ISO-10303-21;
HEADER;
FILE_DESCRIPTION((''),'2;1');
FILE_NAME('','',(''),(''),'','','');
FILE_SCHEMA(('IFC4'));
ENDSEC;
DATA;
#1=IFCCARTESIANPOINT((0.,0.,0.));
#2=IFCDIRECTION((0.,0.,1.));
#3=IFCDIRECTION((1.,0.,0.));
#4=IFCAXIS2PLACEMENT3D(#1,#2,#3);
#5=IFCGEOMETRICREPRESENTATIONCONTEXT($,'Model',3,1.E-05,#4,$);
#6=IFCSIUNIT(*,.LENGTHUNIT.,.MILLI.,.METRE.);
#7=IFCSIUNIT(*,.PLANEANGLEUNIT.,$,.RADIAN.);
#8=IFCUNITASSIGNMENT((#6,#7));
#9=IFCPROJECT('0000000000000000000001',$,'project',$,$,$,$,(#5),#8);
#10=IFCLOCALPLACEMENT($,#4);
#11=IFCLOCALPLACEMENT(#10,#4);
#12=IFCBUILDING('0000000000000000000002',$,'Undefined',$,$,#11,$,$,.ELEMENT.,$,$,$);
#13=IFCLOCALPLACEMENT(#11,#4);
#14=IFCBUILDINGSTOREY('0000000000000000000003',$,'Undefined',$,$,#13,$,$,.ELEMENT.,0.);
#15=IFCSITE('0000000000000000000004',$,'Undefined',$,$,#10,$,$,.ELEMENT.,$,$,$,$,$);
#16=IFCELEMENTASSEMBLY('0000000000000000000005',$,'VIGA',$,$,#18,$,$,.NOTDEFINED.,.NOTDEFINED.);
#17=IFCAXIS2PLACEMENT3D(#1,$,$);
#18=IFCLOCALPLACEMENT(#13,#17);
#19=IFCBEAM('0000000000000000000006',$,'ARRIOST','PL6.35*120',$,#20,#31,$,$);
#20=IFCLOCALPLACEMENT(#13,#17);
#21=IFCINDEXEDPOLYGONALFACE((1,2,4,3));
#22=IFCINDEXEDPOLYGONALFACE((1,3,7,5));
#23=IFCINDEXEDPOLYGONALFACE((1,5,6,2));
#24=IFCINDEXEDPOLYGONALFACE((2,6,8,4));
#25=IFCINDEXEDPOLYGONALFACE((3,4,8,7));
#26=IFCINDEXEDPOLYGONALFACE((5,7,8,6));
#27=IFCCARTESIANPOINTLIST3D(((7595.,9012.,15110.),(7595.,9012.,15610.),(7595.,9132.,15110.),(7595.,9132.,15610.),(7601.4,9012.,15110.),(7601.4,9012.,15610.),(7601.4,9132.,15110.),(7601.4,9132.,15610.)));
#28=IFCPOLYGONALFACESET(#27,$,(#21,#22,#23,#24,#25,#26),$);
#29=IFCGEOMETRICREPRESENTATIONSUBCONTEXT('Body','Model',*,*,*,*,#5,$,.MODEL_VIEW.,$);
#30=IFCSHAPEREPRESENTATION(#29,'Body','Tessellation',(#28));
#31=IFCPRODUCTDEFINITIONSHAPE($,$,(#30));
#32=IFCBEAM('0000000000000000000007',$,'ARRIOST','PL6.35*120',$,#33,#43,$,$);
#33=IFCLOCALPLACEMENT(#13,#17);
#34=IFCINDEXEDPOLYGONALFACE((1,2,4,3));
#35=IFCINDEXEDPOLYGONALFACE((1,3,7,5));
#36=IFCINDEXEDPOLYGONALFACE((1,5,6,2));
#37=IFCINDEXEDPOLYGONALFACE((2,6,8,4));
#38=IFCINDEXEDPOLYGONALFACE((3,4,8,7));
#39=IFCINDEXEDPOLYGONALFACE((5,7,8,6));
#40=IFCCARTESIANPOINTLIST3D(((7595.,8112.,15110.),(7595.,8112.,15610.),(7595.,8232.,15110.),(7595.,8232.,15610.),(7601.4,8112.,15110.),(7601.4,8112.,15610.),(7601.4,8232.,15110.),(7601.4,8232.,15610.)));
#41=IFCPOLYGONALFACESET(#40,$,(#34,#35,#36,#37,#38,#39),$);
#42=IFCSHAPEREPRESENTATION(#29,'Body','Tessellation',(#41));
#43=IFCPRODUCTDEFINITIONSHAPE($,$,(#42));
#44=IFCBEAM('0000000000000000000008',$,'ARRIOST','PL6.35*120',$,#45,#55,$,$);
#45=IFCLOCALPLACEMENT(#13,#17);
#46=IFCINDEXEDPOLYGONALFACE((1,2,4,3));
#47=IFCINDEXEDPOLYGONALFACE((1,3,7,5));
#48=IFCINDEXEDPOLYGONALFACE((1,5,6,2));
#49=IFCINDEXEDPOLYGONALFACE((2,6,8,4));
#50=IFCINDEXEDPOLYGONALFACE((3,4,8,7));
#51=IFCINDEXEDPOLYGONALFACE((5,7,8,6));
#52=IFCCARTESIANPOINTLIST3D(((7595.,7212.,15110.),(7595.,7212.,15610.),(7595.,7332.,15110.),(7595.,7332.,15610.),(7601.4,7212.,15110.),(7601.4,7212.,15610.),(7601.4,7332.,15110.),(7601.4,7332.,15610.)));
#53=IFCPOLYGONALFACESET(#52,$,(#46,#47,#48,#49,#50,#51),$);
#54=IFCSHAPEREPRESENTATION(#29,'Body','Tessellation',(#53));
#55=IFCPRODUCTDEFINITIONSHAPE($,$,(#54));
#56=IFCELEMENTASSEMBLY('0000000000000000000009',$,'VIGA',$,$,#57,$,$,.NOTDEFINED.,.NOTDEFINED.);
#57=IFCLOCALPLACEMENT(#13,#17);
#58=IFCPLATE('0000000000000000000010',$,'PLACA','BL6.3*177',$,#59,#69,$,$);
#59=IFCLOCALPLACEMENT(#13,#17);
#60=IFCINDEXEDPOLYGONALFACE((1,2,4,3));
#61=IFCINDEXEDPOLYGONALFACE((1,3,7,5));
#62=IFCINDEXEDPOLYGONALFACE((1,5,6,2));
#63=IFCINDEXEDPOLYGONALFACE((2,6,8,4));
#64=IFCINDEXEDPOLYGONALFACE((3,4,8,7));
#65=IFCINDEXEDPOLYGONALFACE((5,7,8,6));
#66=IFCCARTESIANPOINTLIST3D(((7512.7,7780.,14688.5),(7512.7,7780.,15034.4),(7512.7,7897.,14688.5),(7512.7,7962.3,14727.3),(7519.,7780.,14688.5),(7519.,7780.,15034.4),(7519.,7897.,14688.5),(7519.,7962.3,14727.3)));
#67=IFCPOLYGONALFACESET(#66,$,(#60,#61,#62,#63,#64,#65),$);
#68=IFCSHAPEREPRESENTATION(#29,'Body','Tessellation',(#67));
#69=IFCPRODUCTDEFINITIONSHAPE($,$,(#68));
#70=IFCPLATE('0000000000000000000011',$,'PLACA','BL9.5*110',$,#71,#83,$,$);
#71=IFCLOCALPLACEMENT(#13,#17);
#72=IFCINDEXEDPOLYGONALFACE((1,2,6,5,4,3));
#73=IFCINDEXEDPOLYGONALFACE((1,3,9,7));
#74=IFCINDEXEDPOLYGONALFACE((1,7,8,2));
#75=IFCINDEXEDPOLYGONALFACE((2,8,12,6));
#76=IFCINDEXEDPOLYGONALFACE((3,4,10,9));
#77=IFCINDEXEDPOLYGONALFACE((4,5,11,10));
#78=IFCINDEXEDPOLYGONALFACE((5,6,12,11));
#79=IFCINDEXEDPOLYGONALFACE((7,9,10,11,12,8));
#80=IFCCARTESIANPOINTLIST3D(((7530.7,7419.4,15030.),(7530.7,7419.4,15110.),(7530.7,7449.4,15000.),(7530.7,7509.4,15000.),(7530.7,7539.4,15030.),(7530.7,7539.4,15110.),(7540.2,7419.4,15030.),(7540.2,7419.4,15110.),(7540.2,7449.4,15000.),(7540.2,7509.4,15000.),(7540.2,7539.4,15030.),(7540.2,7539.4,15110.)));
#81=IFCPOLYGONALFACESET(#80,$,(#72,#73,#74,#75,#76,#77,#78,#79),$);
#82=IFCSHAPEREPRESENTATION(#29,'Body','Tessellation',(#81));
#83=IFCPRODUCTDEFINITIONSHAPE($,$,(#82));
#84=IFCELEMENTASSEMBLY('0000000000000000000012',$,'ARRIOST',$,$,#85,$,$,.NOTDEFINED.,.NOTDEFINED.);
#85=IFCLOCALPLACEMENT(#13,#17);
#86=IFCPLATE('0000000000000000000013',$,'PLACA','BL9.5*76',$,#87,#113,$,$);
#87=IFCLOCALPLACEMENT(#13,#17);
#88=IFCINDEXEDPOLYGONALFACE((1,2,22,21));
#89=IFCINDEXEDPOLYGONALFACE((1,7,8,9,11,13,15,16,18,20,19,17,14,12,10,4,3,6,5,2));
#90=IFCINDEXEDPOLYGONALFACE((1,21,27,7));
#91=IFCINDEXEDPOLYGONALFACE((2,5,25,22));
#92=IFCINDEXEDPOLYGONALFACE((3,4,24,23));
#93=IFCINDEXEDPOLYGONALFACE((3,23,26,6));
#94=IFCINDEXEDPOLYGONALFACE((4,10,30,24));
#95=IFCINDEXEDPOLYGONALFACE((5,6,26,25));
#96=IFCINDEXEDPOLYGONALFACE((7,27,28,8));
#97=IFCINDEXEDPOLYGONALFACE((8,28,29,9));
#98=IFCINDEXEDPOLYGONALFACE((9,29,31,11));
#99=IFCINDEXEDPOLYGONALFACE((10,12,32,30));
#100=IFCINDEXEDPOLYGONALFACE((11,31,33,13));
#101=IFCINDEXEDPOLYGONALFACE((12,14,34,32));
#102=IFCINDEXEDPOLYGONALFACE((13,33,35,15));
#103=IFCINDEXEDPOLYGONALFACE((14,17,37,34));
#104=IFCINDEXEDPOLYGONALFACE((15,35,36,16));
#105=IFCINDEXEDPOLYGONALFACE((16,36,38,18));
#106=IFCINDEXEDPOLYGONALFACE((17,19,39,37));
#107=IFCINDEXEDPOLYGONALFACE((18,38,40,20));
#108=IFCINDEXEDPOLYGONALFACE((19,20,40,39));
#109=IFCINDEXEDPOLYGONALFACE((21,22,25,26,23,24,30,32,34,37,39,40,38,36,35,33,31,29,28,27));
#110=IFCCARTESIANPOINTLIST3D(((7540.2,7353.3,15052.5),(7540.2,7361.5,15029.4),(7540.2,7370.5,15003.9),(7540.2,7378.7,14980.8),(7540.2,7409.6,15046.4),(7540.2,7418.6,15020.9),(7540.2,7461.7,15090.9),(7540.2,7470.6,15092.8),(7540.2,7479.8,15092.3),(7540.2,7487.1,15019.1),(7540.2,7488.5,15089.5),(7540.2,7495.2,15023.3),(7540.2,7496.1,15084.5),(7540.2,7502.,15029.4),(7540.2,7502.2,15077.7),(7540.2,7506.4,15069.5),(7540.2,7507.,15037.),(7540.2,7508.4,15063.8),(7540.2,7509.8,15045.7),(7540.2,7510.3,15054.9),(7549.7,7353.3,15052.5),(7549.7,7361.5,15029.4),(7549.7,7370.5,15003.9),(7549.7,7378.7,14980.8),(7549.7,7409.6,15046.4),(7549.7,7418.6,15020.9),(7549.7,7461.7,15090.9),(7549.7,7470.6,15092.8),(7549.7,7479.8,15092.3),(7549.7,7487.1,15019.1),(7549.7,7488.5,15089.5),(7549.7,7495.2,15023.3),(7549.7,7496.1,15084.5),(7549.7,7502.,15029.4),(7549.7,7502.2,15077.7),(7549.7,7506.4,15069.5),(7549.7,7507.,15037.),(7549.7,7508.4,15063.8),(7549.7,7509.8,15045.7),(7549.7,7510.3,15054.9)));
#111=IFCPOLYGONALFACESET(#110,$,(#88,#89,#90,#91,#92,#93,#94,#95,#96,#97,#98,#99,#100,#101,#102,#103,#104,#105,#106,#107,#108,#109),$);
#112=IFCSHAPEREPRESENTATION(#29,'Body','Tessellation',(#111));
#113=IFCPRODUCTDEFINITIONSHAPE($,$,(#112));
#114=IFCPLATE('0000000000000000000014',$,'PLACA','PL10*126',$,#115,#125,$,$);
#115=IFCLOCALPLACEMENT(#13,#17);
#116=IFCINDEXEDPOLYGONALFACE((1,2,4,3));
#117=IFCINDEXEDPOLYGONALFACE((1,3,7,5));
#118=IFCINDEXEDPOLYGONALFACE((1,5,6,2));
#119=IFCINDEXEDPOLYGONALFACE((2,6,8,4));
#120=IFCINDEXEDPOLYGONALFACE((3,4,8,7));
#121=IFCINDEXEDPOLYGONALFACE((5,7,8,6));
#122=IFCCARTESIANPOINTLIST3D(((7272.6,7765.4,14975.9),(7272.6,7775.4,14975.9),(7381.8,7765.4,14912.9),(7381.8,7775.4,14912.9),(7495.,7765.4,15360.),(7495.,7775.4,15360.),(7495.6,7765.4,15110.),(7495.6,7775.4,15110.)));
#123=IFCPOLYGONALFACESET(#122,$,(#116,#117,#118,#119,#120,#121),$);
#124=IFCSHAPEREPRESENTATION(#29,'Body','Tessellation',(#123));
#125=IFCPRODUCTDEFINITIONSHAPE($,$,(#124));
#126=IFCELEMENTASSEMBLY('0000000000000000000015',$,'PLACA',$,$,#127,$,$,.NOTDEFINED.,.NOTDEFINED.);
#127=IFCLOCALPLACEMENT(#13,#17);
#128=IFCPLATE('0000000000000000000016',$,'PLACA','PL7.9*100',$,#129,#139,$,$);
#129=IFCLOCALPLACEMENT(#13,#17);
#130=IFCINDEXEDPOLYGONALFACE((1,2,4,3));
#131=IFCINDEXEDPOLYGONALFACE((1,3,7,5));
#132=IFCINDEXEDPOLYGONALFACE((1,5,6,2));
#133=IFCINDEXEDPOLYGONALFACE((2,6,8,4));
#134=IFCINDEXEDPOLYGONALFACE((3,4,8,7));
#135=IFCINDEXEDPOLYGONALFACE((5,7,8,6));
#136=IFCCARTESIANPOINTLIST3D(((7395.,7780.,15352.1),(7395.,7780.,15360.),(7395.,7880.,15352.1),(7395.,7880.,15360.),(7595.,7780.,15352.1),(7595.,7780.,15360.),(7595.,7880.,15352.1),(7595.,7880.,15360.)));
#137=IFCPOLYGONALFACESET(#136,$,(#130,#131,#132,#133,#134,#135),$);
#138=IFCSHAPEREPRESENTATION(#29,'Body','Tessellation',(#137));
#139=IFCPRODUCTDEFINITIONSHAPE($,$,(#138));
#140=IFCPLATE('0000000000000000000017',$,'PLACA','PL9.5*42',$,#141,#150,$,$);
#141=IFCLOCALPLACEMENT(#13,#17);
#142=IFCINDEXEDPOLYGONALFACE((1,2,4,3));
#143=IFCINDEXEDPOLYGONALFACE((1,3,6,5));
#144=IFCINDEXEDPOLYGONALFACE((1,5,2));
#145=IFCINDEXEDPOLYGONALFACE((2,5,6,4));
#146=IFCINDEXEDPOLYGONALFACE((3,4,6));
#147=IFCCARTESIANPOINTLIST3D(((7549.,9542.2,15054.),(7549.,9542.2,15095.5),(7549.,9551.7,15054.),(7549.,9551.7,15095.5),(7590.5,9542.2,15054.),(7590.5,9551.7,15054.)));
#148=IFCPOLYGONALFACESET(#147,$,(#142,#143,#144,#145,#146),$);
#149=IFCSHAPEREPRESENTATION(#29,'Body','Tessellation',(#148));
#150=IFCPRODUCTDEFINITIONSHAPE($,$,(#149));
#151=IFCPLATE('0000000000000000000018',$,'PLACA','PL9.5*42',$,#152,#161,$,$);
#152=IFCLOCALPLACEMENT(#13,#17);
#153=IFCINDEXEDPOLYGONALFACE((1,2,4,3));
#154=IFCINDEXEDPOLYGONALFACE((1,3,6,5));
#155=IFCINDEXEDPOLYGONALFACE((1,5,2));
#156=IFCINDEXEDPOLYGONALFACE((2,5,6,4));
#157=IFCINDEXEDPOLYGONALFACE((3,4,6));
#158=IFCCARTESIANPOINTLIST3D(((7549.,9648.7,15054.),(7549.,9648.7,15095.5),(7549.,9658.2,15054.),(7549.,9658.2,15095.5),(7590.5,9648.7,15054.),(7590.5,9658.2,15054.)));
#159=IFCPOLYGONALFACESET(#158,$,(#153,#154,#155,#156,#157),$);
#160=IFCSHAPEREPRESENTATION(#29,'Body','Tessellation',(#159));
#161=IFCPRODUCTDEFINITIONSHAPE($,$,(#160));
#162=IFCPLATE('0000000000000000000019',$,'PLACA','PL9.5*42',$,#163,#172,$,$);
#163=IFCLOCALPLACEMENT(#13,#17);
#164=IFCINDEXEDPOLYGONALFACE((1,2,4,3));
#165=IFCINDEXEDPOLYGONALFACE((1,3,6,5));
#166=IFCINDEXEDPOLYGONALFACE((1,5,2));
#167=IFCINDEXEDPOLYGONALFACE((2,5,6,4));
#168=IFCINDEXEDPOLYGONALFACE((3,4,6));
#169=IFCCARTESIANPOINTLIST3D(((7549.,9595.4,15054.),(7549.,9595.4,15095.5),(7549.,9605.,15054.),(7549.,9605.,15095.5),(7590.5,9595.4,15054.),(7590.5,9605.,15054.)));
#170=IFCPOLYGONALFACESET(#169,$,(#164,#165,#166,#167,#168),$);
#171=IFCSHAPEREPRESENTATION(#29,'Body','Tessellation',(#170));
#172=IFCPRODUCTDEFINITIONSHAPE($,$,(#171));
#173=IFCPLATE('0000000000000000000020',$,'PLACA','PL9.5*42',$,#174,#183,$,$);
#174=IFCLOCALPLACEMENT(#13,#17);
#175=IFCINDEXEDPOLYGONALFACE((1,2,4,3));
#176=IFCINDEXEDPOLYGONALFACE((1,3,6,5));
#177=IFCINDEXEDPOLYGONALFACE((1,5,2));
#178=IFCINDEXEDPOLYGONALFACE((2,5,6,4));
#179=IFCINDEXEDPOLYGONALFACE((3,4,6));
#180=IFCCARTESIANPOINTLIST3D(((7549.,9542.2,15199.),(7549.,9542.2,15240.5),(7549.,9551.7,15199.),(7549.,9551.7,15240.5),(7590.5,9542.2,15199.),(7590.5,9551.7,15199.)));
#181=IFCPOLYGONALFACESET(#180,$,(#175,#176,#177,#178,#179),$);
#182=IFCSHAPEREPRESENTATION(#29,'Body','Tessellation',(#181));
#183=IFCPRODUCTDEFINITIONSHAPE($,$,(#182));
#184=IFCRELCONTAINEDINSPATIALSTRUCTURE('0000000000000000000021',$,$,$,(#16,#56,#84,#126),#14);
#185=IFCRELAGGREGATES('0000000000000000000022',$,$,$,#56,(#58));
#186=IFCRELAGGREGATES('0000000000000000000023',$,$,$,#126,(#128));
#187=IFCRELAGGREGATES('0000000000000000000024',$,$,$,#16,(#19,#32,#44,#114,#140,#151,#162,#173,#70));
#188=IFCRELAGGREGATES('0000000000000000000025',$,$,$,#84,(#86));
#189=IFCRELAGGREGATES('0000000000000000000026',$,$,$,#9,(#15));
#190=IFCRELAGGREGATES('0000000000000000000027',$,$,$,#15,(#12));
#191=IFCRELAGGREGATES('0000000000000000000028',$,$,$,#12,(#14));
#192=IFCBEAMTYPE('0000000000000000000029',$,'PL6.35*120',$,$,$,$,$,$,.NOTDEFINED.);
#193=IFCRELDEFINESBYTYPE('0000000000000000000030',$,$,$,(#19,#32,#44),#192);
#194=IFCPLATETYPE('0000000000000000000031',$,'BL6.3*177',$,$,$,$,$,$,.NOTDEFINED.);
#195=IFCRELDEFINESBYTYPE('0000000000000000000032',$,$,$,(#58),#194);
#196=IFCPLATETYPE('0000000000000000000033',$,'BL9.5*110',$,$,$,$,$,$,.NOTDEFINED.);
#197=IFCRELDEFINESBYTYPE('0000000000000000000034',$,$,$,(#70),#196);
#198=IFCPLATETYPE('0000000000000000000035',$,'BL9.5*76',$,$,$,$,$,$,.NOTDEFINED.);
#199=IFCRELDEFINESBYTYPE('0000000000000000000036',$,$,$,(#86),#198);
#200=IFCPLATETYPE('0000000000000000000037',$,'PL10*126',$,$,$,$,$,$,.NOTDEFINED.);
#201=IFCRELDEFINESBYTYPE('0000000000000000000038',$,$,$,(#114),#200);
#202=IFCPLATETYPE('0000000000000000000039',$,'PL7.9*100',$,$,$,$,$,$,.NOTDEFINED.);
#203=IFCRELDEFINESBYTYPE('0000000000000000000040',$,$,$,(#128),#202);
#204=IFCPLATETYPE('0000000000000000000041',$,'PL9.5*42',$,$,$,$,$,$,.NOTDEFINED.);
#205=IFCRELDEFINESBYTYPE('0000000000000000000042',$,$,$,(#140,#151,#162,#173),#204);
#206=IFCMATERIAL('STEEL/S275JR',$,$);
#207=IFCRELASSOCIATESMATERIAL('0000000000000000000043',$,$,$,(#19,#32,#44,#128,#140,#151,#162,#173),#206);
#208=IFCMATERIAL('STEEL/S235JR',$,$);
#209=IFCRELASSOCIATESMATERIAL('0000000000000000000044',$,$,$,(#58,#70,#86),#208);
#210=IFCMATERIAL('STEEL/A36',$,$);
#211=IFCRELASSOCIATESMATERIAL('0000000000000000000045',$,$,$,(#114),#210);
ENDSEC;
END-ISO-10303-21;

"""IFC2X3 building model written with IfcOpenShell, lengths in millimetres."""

from ifc_helpers import new_model, si_unit, frame, frame_2d, origin_with_axes, origin_2d_with_axis, place, context, subcontext, project, spatial, polyline, circle_curve, parameter, trimmed, segment, composite_curve, rectangle, outline, extrude, boolean, material, type_object, element, aggregate, save


model = new_model("IFC2X3")

# Units and contexts
model_context = context("Model", 3, precision=1e-05, world=origin_with_axes())
body_context = subcontext(model_context, "Body", "Model", "MODEL_VIEW")
ifc_project = project(units=[si_unit("LENGTHUNIT", "METRE", prefix="MILLI"), si_unit("PLANEANGLEUNIT", "RADIAN")], contexts=[model_context])

# Site, building, storey
site_placement = place(None, origin_with_axes())
site = spatial("IfcSite", under=ifc_project, at=site_placement, Name="Undefined", CompositionType="ELEMENT")
building_placement = place(site_placement, origin_with_axes())
building = spatial("IfcBuilding", under=site, at=building_placement, Name="Undefined", CompositionType="ELEMENT")
storey_placement = place(building_placement, origin_with_axes())
storey = spatial("IfcBuildingStorey", under=building, at=storey_placement, Name="Undefined", CompositionType="ELEMENT", Elevation=0.0)

# Element assembly, beams
assembly_1_placement = place(storey_placement, origin_with_axes())
assembly_1 = element("IfcElementAssembly", 1, at=assembly_1_placement, inside=storey, Name="VIGA", AssemblyPlace="NOTDEFINED", PredefinedType="NOTDEFINED")
ifc_material_1 = material(Name="STEEL/S275JR")
beam_type_1 = type_object("IfcBeamType", Name="PL6.35*120", PredefinedType="NOTDEFINED")
beam_1_placement = place(assembly_1_placement, frame((7598.2, 9072.0, 15110.0), z_axis=(0.0, 1.0, 0.0), x_axis=(0.0, 0.0, 1.0)))
beam_1 = element("IfcBeam", 2, at=beam_1_placement, type_object=beam_type_1, material=ifc_material_1, Name="ARRIOST", Description="PL6.35*120", context=body_context, shape_type="SweptSolid", body=[
    extrude(rectangle(XDim=6.3, YDim=120.0, at=origin_2d_with_axis()), frame((500.0, 0.0, 0.0), z_axis=(-1.0, 0.0, 0.0), x_axis=(0.0, -1.0, 0.0)), (0.0, 0.0, 1.0), 500.0),
])
beam_2_placement = place(assembly_1_placement, frame((7598.2, 8172.0, 15110.0), z_axis=(0.0, 1.0, 0.0), x_axis=(0.0, 0.0, 1.0)))
beam_2 = element("IfcBeam", 3, at=beam_2_placement, type_object=beam_type_1, material=ifc_material_1, Name="ARRIOST", Description="PL6.35*120", context=body_context, shape_type="SweptSolid", body=[
    extrude(rectangle(XDim=6.3, YDim=120.0, at=origin_2d_with_axis()), frame((500.0, 0.0, 0.0), z_axis=(-1.0, 0.0, 0.0), x_axis=(0.0, -1.0, 0.0)), (0.0, 0.0, 1.0), 500.0),
])
beam_3_placement = place(assembly_1_placement, frame((7598.2, 7272.0, 15110.0), z_axis=(0.0, 1.0, 0.0), x_axis=(0.0, 0.0, 1.0)))
beam_3 = element("IfcBeam", 4, at=beam_3_placement, type_object=beam_type_1, material=ifc_material_1, Name="ARRIOST", Description="PL6.35*120", context=body_context, shape_type="SweptSolid", body=[
    extrude(rectangle(XDim=6.3, YDim=120.0, at=origin_2d_with_axis()), frame((500.0, 0.0, 0.0), z_axis=(-1.0, 0.0, 0.0), x_axis=(0.0, -1.0, 0.0)), (0.0, 0.0, 1.0), 500.0),
])

# Element assembly, plate
assembly_2_placement = place(storey_placement, origin_with_axes())
assembly_2 = element("IfcElementAssembly", 5, at=assembly_2_placement, inside=storey, Name="VIGA", AssemblyPlace="NOTDEFINED", PredefinedType="NOTDEFINED")
ifc_material_2 = material(Name="STEEL/S235JR")
plate_type_1 = type_object("IfcPlateType", Name="BL6.3*177", PredefinedType="NOTDEFINED")
plate_1_placement = place(assembly_2_placement, frame((7515.9, 7780.0, 15034.4), z_axis=(1.0, 0.0, 0.0), x_axis=(0.0, 0.0, -1.0)))
plate_1 = element("IfcPlate", 6, at=plate_1_placement, type_object=plate_type_1, material=ifc_material_2, Name="PLACA", Description="BL6.3*177", context=body_context, shape_type="SweptSolid", body=[
    extrude(outline(polyline([(0.0, 0.0), (346.0, 0.0), (346.0, 117.0), (307.2, 182.3), (0.0, 0.0)])), frame((0.0, 0.0, -3.1), z_axis=(0.0, 0.0, 1.0), x_axis=(1.0, 0.0, 0.0)), (0.0, 0.0, 1.0), 6.3),
])
aggregate(assembly_2, [plate_1])

# Plate
plate_type_2 = type_object("IfcPlateType", Name="BL9.5*110", PredefinedType="NOTDEFINED")
plate_2_placement = place(assembly_1_placement, frame((7535.5, 7419.4, 15110.0), z_axis=(1.0, 0.0, 0.0), x_axis=(0.0, 0.0, -1.0)))
plate_2 = element("IfcPlate", 7, at=plate_2_placement, type_object=plate_type_2, material=ifc_material_2, Name="PLACA", Description="BL9.5*110", context=body_context, shape_type="SweptSolid", body=[
    extrude(outline(polyline([(0.0, 0.0), (80.0, 0.0), (110.0, 30.0), (110.0, 90.0), (80.0, 120.0), (0.0, 120.0), (0.0, 0.0)])), frame((0.0, 0.0, -4.7), z_axis=(0.0, 0.0, 1.0), x_axis=(1.0, 0.0, 0.0)), (0.0, 0.0, 1.0), 9.5),
])

# Element assembly, plate
assembly_3_placement = place(storey_placement, origin_with_axes())
assembly_3 = element("IfcElementAssembly", 8, at=assembly_3_placement, inside=storey, Name="ARRIOST", AssemblyPlace="NOTDEFINED", PredefinedType="NOTDEFINED")
plate_type_3 = type_object("IfcPlateType", Name="BL9.5*76", PredefinedType="NOTDEFINED")
plate_3_placement = place(assembly_3_placement, frame((7545.0, 7520.1, 15030.8), z_axis=(1.0, 0.0, 0.0), x_axis=(0.0, -0.333429, 0.942775)))
plate_3 = element("IfcPlate", 9, at=plate_3_placement, type_object=plate_type_3, material=ifc_material_2, Name="PLACA", Description="BL9.5*76", context=body_context, shape_type="CSG", body=[
    boolean("DIFFERENCE", extrude(outline(composite_curve([segment(trimmed(circle_curve(frame_2d((35.0, 35.0), x_axis=(-1.0, 0.0)), 35.0), [parameter(0.0)], [parameter(1.570796)], True, "PARAMETER"), True, "CONTINUOUS"), segment(polyline([(35.0, 0.0), (41.1, 0.0)]), True, "CONTINUOUS"), segment(trimmed(circle_curve(frame_2d((41.1, 35.0), x_axis=(0.0, -1.0)), 35.0), [parameter(0.0)], [parameter(1.570796)], True, "PARAMETER"), True, "CONTINUOUS"), segment(polyline([(76.1, 35.0), (76.1, 150.0), (0.0, 150.0), (0.0, 35.0)]), True, "CONTINUOUS")], self_intersect=True)), frame((0.0, 0.0, -4.7), z_axis=(0.0, 0.0, 1.0), x_axis=(1.0, 0.0, 0.0)), (0.0, 0.0, 1.0), 9.5), extrude(rectangle(XDim=27.0, YDim=27.0, at=origin_2d_with_axis()), frame((38.0, 250.0, 0.0), z_axis=(0.0, -1.0, 0.0), x_axis=(0.0, 0.0, 1.0)), (0.0, 0.0, 1.0), 151.0)),
])

# Plate
ifc_material_3 = material(Name="STEEL/A36")
plate_type_4 = type_object("IfcPlateType", Name="PL10*126", PredefinedType="NOTDEFINED")
plate_4_placement = place(assembly_1_placement, frame((7495.0, 7770.4, 15360.0), z_axis=(0.0, -1.0, 0.0), x_axis=(-0.500975, 0.0, -0.865462)))
plate_4 = element("IfcPlate", 10, at=plate_4_placement, type_object=plate_type_4, material=ifc_material_3, Name="PLACA", Description="PL10*126", context=body_context, shape_type="SweptSolid", body=[
    extrude(outline(polyline([(0.0, 0.0), (443.9, 0.0), (443.7, 126.0), (216.1, 125.7), (0.0, 0.0)])), frame((0.0, 0.0, -5.0), z_axis=(0.0, 0.0, 1.0), x_axis=(1.0, 0.0, 0.0)), (0.0, 0.0, 1.0), 10.0),
])

# Element assembly, plate
assembly_4_placement = place(storey_placement, origin_with_axes())
assembly_4 = element("IfcElementAssembly", 11, at=assembly_4_placement, inside=storey, Name="PLACA", AssemblyPlace="NOTDEFINED", PredefinedType="NOTDEFINED")
plate_type_5 = type_object("IfcPlateType", Name="PL7.9*100", PredefinedType="NOTDEFINED")
plate_5_placement = place(assembly_4_placement, frame((7395.0, 7880.0, 15356.0), z_axis=(0.0, 0.0, 1.0), x_axis=(0.0, -1.0, 0.0)))
plate_5 = element("IfcPlate", 12, at=plate_5_placement, type_object=plate_type_5, material=ifc_material_1, Name="PLACA", Description="PL7.9*100", context=body_context, shape_type="SweptSolid", body=[
    extrude(outline(polyline([(0.0, 0.0), (100.0, 0.0), (100.0, 200.0), (0.0, 200.0), (0.0, 0.0)])), frame((0.0, 0.0, -4.0), z_axis=(0.0, 0.0, 1.0), x_axis=(1.0, 0.0, 0.0)), (0.0, 0.0, 1.0), 7.9),
])
aggregate(assembly_4, [plate_5])

# Plates
plate_type_6 = type_object("IfcPlateType", Name="PL9.5*42", PredefinedType="NOTDEFINED")
plate_6_placement = place(assembly_1_placement, frame((7549.0, 9547.0, 15054.0), z_axis=(0.0, 1.0, 0.0), x_axis=(0.0, 0.0, 1.0)))
plate_6 = element("IfcPlate", 13, at=plate_6_placement, type_object=plate_type_6, material=ifc_material_1, Name="PLACA", Description="PL9.5*42", context=body_context, shape_type="SweptSolid", body=[
    extrude(outline(polyline([(0.0, 0.0), (41.5, 0.0), (0.0, 41.5), (0.0, 0.0)])), frame((0.0, 0.0, -4.7), z_axis=(0.0, 0.0, 1.0), x_axis=(1.0, 0.0, 0.0)), (0.0, 0.0, 1.0), 9.5),
])
plate_7_placement = place(assembly_1_placement, frame((7549.0, 9653.5, 15054.0), z_axis=(0.0, 1.0, 0.0), x_axis=(0.0, 0.0, 1.0)))
plate_7 = element("IfcPlate", 14, at=plate_7_placement, type_object=plate_type_6, material=ifc_material_1, Name="PLACA", Description="PL9.5*42", context=body_context, shape_type="SweptSolid", body=[
    extrude(outline(polyline([(0.0, 0.0), (41.5, 0.0), (0.0, 41.5), (0.0, 0.0)])), frame((0.0, 0.0, -4.7), z_axis=(0.0, 0.0, 1.0), x_axis=(1.0, 0.0, 0.0)), (0.0, 0.0, 1.0), 9.5),
])
plate_8_placement = place(assembly_1_placement, frame((7549.0, 9600.2, 15054.0), z_axis=(0.0, 1.0, 0.0), x_axis=(0.0, 0.0, 1.0)))
plate_8 = element("IfcPlate", 15, at=plate_8_placement, type_object=plate_type_6, material=ifc_material_1, Name="PLACA", Description="PL9.5*42", context=body_context, shape_type="SweptSolid", body=[
    extrude(outline(polyline([(0.0, 0.0), (41.5, 0.0), (0.0, 41.5), (0.0, 0.0)])), frame((0.0, 0.0, -4.7), z_axis=(0.0, 0.0, 1.0), x_axis=(1.0, 0.0, 0.0)), (0.0, 0.0, 1.0), 9.5),
])
plate_9_placement = place(assembly_1_placement, frame((7549.0, 9547.0, 15199.0), z_axis=(0.0, 1.0, 0.0), x_axis=(0.0, 0.0, 1.0)))
plate_9 = element("IfcPlate", 16, at=plate_9_placement, type_object=plate_type_6, material=ifc_material_1, Name="PLACA", Description="PL9.5*42", context=body_context, shape_type="SweptSolid", body=[
    extrude(outline(polyline([(0.0, 0.0), (41.5, 0.0), (0.0, 41.5), (0.0, 0.0)])), frame((0.0, 0.0, -4.7), z_axis=(0.0, 0.0, 1.0), x_axis=(1.0, 0.0, 0.0)), (0.0, 0.0, 1.0), 9.5),
])
aggregate(assembly_1, [beam_1, beam_2, beam_3, plate_4, plate_6, plate_7, plate_8, plate_9, plate_2])

aggregate(assembly_3, [plate_3])

save(model, "model.ifc")
